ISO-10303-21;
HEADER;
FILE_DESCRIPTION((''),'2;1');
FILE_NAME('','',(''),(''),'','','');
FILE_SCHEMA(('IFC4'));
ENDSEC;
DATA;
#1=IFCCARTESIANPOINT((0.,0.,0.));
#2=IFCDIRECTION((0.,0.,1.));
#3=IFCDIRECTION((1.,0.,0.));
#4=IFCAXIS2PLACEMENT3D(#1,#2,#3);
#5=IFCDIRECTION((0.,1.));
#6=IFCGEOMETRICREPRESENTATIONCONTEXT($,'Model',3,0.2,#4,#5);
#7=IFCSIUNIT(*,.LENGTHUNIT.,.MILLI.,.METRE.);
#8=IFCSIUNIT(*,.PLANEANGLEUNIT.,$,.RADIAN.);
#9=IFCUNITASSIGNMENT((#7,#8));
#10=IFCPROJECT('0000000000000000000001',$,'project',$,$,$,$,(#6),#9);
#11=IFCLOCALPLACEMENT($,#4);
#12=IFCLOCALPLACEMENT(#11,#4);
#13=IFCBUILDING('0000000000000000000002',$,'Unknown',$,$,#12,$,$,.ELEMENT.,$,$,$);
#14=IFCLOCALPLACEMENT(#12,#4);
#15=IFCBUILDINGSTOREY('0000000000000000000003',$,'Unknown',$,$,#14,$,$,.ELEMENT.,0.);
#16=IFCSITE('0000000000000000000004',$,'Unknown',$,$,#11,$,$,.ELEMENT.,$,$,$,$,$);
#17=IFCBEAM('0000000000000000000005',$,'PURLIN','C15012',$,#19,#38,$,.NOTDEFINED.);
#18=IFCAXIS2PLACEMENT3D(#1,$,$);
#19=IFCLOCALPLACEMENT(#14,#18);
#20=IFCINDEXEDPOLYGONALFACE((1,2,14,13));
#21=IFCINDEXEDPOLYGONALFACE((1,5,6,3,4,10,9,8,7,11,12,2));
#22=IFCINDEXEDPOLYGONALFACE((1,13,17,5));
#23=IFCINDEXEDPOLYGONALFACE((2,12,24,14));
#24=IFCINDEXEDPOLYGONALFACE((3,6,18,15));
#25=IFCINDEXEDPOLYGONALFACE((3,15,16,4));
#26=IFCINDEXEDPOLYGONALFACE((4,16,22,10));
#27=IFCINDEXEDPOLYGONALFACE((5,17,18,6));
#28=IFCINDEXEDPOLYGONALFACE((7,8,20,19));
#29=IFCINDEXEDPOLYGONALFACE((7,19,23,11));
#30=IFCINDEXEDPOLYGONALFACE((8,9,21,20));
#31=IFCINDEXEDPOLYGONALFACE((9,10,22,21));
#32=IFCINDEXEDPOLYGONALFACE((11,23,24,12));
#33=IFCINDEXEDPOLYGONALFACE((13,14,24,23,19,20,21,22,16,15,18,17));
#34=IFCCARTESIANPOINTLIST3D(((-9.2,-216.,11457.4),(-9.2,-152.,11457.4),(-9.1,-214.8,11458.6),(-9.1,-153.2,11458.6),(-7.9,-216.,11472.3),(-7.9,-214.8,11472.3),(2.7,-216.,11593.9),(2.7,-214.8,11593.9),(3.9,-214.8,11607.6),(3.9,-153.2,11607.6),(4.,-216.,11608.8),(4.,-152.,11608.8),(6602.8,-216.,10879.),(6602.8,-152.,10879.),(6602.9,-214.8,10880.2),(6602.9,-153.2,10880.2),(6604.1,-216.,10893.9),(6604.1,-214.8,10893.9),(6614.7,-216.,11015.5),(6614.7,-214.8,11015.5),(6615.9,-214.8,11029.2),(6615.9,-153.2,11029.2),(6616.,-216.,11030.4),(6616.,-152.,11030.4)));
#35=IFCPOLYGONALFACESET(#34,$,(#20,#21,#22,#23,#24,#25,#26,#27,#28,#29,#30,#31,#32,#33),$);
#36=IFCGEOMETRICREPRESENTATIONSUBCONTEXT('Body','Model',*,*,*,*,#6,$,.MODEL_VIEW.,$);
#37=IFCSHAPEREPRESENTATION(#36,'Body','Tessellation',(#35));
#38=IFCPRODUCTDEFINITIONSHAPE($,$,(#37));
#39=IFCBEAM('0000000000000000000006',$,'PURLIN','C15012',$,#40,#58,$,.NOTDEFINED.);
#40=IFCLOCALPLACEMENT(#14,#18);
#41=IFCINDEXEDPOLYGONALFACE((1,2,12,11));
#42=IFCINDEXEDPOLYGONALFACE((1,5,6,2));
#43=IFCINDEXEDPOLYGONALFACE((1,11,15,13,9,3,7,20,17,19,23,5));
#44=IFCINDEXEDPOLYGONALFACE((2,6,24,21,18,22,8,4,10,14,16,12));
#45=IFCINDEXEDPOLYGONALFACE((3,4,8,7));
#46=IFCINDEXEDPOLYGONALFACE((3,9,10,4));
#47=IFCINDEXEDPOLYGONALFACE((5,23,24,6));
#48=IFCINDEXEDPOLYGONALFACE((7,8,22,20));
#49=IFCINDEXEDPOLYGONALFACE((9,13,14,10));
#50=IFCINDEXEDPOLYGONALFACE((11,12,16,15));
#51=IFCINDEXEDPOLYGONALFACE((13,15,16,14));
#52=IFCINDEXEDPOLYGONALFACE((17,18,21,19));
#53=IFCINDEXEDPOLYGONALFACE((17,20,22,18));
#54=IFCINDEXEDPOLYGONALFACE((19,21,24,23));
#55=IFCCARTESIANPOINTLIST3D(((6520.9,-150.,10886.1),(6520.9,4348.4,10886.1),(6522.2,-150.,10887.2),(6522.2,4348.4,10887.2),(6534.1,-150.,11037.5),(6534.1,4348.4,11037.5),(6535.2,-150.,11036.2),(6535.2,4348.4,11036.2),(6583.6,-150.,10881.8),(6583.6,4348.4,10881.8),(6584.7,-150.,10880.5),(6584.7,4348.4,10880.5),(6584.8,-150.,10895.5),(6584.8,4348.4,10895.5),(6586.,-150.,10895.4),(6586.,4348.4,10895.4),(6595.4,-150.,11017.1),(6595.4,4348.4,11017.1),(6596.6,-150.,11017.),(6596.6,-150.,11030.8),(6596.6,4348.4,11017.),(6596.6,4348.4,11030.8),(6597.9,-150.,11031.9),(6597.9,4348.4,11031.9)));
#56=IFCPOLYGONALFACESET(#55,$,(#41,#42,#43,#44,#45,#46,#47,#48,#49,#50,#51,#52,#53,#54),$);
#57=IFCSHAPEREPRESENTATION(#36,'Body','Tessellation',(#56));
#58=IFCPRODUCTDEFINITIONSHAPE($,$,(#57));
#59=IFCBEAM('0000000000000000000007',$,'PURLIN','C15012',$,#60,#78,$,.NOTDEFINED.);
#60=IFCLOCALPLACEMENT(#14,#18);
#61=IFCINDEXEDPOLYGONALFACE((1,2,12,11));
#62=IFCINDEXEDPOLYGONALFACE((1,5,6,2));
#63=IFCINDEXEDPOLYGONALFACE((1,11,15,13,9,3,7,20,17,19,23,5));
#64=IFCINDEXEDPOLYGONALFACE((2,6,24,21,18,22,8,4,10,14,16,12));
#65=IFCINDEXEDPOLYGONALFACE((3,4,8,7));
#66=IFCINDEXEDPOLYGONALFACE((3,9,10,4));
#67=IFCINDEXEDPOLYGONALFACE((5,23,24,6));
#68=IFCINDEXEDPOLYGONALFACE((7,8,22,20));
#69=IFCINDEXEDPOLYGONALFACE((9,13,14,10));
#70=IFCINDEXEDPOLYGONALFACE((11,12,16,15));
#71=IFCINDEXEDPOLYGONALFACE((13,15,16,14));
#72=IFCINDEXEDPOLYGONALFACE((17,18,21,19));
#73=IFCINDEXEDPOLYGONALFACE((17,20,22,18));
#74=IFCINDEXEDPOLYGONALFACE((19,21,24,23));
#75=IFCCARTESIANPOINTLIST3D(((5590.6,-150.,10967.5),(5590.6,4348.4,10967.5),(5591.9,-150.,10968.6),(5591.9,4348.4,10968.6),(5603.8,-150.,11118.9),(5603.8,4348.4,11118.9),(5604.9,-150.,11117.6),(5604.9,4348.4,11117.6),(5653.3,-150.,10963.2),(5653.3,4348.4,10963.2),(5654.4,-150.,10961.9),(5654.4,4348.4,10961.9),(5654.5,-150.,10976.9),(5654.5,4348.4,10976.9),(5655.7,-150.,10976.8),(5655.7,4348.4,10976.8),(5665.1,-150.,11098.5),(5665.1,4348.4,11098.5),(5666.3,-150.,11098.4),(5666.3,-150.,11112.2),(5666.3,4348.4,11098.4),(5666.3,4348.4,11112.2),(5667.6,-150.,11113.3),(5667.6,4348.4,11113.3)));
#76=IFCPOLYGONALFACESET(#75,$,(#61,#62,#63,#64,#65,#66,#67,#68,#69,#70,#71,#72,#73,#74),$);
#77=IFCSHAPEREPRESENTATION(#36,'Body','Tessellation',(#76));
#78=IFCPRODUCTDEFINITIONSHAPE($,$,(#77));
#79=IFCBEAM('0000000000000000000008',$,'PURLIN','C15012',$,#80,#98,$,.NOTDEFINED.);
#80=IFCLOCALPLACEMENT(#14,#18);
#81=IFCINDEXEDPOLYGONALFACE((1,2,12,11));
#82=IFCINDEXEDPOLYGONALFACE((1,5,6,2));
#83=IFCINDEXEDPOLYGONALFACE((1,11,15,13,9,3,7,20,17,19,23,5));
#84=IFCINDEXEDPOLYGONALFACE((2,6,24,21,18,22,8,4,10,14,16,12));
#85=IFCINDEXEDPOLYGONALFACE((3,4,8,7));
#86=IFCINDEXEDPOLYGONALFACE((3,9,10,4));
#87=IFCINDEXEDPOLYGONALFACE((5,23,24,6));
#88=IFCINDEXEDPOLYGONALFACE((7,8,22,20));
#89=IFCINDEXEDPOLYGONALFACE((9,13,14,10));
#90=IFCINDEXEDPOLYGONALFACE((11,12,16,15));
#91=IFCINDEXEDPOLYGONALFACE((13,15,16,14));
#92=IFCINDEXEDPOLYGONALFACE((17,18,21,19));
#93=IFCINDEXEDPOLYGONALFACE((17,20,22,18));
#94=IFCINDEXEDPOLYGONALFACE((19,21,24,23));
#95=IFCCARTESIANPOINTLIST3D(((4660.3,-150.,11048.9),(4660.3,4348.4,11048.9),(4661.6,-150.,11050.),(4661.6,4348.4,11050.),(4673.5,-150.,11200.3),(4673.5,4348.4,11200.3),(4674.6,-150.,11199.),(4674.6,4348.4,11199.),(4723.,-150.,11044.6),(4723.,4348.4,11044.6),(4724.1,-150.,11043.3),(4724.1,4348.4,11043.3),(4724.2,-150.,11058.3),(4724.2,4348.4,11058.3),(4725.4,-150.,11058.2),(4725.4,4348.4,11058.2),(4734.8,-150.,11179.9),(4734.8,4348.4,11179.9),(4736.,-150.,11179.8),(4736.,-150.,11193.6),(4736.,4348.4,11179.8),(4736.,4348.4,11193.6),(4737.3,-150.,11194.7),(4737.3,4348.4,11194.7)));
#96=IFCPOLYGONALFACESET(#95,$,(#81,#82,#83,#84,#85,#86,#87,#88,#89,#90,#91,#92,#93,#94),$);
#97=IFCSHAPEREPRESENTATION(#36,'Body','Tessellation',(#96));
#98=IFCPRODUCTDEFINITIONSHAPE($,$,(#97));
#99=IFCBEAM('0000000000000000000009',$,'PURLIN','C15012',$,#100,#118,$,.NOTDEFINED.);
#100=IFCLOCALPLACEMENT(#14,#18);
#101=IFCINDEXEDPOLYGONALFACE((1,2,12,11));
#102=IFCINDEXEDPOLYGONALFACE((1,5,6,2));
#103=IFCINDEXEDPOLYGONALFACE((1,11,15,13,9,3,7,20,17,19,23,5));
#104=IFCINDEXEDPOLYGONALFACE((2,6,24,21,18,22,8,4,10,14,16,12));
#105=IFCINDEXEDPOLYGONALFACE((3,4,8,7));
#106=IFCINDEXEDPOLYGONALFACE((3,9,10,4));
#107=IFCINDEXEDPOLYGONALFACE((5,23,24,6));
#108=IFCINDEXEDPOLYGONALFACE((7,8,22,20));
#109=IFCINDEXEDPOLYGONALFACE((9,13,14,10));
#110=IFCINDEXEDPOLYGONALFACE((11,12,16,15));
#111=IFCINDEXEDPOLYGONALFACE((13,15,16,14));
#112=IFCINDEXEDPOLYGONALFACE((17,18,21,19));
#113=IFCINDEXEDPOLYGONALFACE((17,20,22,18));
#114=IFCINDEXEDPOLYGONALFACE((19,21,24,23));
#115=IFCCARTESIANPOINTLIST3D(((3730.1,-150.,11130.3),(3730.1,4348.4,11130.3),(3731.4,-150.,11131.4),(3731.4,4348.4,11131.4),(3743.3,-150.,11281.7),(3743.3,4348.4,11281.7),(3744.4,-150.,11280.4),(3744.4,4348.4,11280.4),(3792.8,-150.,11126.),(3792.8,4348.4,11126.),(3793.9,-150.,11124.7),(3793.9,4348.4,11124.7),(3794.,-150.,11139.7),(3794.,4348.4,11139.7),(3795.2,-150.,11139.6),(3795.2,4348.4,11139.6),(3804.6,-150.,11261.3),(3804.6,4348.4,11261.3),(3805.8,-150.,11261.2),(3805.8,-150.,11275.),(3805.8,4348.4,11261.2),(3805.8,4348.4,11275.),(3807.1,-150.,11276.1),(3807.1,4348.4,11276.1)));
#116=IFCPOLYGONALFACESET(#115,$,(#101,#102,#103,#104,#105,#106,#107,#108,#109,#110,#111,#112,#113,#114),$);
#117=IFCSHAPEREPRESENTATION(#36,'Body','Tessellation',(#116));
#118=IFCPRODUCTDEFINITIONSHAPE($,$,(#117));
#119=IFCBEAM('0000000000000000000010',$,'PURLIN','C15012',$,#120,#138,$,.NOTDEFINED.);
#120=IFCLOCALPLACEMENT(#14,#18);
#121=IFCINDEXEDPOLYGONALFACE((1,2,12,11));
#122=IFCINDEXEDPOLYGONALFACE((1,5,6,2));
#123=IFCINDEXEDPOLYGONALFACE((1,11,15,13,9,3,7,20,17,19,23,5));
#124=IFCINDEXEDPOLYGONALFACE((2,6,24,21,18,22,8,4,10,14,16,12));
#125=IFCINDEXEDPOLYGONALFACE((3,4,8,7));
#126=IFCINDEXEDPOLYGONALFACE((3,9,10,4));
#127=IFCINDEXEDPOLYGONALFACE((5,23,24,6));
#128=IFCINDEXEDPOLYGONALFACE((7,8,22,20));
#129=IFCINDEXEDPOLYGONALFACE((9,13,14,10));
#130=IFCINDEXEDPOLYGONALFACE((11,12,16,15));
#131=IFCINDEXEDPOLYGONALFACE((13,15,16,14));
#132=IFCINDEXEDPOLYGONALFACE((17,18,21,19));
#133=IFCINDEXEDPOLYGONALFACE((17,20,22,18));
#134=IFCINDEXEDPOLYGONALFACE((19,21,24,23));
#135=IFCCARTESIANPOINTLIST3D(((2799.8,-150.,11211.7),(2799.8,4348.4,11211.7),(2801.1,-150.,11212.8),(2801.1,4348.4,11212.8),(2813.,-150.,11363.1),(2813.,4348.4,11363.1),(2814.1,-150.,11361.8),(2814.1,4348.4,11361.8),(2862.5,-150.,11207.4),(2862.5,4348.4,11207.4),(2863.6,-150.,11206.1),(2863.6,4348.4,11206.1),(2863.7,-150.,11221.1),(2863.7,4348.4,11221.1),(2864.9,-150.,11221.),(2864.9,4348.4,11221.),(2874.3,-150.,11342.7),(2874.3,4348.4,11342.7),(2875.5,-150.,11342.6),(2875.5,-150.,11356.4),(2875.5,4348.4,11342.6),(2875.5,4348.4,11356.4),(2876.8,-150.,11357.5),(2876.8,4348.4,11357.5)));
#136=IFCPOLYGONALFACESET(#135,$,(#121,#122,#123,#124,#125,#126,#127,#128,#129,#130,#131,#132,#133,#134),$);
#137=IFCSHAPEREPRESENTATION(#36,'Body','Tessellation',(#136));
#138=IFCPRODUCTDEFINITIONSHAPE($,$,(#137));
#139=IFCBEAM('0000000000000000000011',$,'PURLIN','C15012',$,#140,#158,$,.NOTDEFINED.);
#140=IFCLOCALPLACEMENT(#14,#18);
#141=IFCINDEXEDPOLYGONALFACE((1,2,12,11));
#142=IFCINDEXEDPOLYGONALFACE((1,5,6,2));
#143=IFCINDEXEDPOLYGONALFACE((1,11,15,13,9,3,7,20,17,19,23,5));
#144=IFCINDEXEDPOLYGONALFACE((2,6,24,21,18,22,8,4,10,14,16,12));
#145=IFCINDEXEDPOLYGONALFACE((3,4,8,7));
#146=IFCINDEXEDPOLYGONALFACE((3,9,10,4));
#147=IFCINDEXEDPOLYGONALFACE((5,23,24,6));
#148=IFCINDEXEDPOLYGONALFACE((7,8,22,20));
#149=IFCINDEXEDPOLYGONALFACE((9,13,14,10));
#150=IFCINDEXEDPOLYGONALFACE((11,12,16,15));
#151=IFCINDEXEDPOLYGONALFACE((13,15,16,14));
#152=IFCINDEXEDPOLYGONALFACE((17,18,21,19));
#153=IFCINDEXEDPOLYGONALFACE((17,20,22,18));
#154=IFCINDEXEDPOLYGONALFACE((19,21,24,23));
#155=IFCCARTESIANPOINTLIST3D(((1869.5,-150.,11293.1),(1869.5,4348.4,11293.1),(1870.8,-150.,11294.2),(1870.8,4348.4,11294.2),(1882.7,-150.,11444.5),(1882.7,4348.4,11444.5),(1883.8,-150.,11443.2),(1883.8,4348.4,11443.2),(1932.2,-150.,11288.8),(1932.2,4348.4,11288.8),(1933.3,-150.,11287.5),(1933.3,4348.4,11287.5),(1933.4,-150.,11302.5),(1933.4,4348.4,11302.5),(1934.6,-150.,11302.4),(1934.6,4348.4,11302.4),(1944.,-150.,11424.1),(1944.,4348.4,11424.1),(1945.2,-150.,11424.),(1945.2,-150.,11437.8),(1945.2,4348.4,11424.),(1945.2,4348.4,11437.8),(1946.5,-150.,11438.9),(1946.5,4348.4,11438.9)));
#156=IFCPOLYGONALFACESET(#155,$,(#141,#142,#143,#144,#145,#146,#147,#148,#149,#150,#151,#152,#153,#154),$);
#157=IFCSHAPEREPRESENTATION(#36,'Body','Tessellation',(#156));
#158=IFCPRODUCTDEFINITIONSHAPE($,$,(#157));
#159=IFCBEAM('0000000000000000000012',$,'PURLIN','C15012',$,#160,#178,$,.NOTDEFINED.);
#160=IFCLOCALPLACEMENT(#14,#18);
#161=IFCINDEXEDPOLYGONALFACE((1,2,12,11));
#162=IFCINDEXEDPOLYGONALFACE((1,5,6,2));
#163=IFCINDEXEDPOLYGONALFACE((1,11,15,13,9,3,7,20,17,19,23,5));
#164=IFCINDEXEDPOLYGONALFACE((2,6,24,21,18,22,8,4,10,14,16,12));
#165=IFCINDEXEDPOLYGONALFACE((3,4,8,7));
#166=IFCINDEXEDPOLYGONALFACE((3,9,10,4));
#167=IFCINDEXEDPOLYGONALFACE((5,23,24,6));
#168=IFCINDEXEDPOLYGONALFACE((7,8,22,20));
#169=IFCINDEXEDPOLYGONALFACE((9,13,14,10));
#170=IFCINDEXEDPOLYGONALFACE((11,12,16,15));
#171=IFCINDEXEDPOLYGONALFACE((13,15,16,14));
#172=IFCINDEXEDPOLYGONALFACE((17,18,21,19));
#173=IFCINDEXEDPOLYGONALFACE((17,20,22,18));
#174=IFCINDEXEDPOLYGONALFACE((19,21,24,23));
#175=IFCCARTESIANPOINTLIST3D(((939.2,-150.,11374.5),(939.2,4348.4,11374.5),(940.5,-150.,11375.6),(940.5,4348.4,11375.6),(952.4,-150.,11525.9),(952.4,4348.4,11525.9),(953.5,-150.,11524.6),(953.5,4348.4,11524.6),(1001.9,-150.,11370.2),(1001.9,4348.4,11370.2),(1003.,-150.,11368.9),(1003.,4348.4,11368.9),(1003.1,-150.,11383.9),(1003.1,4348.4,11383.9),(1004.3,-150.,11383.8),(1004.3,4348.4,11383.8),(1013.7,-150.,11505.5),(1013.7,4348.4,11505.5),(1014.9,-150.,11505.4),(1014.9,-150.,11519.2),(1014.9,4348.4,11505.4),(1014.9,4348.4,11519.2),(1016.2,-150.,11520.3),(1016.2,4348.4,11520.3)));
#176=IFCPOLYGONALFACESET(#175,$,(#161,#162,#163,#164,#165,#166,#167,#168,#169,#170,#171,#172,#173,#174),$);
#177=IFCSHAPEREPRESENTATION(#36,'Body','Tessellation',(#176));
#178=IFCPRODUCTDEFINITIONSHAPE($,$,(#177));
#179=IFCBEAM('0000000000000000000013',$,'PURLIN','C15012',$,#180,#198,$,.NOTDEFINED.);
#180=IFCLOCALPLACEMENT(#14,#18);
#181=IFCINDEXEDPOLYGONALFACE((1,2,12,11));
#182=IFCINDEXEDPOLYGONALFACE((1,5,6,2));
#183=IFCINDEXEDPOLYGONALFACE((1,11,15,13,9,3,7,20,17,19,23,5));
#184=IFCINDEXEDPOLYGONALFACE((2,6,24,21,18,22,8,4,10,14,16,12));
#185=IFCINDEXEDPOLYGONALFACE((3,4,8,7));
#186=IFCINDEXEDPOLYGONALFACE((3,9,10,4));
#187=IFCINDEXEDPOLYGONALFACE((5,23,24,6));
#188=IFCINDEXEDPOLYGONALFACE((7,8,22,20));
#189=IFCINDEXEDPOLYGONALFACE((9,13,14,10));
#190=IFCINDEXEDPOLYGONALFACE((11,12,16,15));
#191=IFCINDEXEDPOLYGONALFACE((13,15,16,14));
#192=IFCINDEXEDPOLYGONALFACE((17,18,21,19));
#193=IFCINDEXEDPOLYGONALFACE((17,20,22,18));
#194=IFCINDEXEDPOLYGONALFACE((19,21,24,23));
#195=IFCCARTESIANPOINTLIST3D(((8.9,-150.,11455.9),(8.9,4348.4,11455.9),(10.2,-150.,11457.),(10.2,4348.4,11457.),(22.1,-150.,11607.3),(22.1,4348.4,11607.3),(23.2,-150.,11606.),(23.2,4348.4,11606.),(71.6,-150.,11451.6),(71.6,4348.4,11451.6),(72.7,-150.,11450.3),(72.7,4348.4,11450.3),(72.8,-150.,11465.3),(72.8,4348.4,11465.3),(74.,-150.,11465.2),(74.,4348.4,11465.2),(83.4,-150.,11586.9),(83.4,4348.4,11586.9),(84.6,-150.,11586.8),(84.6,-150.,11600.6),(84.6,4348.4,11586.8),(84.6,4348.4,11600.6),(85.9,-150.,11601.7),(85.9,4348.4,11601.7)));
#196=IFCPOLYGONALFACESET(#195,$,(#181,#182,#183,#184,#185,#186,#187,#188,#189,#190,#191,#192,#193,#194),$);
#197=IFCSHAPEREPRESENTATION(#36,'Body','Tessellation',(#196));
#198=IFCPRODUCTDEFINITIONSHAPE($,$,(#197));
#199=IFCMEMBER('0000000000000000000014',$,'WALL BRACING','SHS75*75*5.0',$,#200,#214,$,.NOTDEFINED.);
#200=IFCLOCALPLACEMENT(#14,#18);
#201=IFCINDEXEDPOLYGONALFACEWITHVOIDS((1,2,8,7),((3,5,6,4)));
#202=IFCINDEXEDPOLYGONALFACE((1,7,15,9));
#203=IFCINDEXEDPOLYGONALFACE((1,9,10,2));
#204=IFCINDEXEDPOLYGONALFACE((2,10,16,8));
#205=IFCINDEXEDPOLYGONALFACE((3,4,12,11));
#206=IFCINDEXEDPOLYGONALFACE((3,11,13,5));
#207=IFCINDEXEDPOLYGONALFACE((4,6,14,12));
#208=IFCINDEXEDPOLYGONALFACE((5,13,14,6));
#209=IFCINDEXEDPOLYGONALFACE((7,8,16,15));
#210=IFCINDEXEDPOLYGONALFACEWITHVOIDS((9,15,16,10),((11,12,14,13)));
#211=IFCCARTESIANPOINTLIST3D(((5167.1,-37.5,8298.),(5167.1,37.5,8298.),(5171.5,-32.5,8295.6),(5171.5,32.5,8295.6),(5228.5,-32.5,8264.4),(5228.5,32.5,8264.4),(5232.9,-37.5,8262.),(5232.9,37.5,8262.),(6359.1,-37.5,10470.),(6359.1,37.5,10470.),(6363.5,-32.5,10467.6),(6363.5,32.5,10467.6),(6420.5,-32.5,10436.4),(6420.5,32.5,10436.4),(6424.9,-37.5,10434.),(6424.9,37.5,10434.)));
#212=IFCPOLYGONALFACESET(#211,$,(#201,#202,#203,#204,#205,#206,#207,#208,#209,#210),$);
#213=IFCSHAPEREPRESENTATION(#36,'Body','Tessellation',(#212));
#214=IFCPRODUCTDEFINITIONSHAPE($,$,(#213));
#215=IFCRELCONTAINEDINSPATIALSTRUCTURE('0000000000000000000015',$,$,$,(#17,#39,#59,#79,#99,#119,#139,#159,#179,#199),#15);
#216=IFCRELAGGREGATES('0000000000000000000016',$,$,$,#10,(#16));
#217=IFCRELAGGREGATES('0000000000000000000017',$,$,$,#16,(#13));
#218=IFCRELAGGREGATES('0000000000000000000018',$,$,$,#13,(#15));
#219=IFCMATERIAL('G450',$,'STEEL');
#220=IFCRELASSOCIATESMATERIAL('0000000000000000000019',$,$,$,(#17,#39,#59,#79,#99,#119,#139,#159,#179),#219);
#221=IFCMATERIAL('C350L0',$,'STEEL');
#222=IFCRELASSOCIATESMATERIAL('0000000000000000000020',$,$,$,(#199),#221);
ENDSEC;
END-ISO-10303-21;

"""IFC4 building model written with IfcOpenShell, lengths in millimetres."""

from ifc_helpers import new_model, si_unit, direction, frame, origin_with_axes, place, context, subcontext, project, spatial, line, indexed_curve, outline, extrude, material, element, save


model = new_model("IFC4")

# Units and contexts
model_context = context("Model", 3, precision=0.2, world=origin_with_axes(), true_north=direction((0.0, 1.0)))
body_context = subcontext(model_context, "Body", "Model", "MODEL_VIEW")
ifc_project = project(units=[si_unit("LENGTHUNIT", "METRE", prefix="MILLI"), si_unit("PLANEANGLEUNIT", "RADIAN")], contexts=[model_context])

# Site, building, storey
site_placement = place(None, origin_with_axes())
site = spatial("IfcSite", under=ifc_project, at=site_placement, Name="Unknown", CompositionType="ELEMENT")
building_placement = place(site_placement, origin_with_axes())
building = spatial("IfcBuilding", under=site, at=building_placement, Name="Unknown", CompositionType="ELEMENT")
storey_placement = place(building_placement, origin_with_axes())
storey = spatial("IfcBuildingStorey", under=building, at=storey_placement, Name="Unknown", CompositionType="ELEMENT", Elevation=0.0)

# Shared definitions
ifc_material_1 = material(Name="C350L0", Category="STEEL")

# Beams
ifc_material_2 = material(Name="G450", Category="STEEL")
beam_placement = place(storey_placement, frame((-2.6, -184.0, 11533.1), z_axis=(0.0, -1.0, 0.0), x_axis=(0.996196, 0.0, -0.087145)))
element("IfcBeam", 1, at=beam_placement, inside=storey, material=ifc_material_2, Name="PURLIN", Description="C15012", PredefinedType="NOTDEFINED", context=body_context, shape_type="SolidModel", body=[
    extrude(outline(indexed_curve([(32.0, -76.0), (32.0, -61.0), (30.8, -61.0), (30.8, -74.8), (-30.8, -74.8), (-30.8, 74.8), (30.8, 74.8), (30.8, 61.0), (32.0, 61.0), (32.0, 76.0), (-32.0, 76.0), (-32.0, -76.0)], segments=[line(1, 2, 3, 4, 5, 6, 7, 8, 9, 10, 11, 12, 1)])), frame((0.0, 0.0, 0.0), z_axis=(-1.0, 0.0, 0.0), x_axis=(0.0, 0.0, 1.0)), (0.0, 0.0, -1.0), 6637.3),
])
for number, where, z_axis, x_axis, name in (
    (2, (6559.4, -150.0, 10959.0), (0.996195, 0.0, -0.087156), (0.0, 1.0, 0.0), "PURLIN"),
    (3, (5629.1, -150.0, 11040.4), (0.996195, 0.0, -0.087156), (0.0, 1.0, 0.0), "PURLIN"),
    (4, (4698.8, -150.0, 11121.8), (0.996195, 0.0, -0.087156), (0.0, 1.0, 0.0), "PURLIN"),
    (5, (3768.6, -150.0, 11203.2), (0.996195, 0.0, -0.087156), (0.0, 1.0, 0.0), "PURLIN"),
    (6, (2838.3, -150.0, 11284.6), (0.996195, 0.0, -0.087156), (0.0, 1.0, 0.0), "PURLIN"),
    (7, (1908.0, -150.0, 11366.0), (0.996195, 0.0, -0.087156), (0.0, 1.0, 0.0), "PURLIN"),
    (8, (977.7, -150.0, 11447.4), (0.996195, 0.0, -0.087156), (0.0, 1.0, 0.0), "PURLIN"),
    (9, (47.4, -150.0, 11528.8), (0.996195, 0.0, -0.087156), (0.0, 1.0, 0.0), "PURLIN"),
):
    element("IfcBeam", number, at=place(storey_placement, frame(where, z_axis=z_axis, x_axis=x_axis)), inside=storey, material=ifc_material_2, Name=name, Description="C15012", PredefinedType="NOTDEFINED", context=body_context, shape_type="SolidModel", body=[
        extrude(outline(indexed_curve([(32.0, -76.0), (32.0, -61.0), (30.8, -61.0), (30.8, -74.8), (-30.8, -74.8), (-30.8, 74.8), (30.8, 74.8), (30.8, 61.0), (32.0, 61.0), (32.0, 76.0), (-32.0, 76.0), (-32.0, -76.0)], segments=[line(1, 2, 3, 4, 5, 6, 7, 8, 9, 10, 11, 12, 1)])), frame((0.0, 0.0, 0.0), z_axis=(-1.0, 0.0, 0.0), x_axis=(0.0, 0.0, 1.0)), (0.0, 0.0, -1.0), 4498.4),
    ])

# Member
member_1_placement = place(storey_placement, frame((6392.0, 0.0, 10452.0), z_axis=(-0.876659, 0.0, 0.481113), x_axis=(-0.481113, 0.0, -0.876659)))
element("IfcMember", 10, at=member_1_placement, inside=storey, material=ifc_material_1, Name="WALL BRACING", Description="SHS75*75*5.0", PredefinedType="NOTDEFINED", context=body_context, shape_type="SolidModel", body=[
    extrude(outline(indexed_curve([(-37.5, -37.5), (37.5, -37.5), (37.5, 37.5), (-37.5, 37.5)], segments=[line(1, 2, 3, 4, 1)]), holes=[indexed_curve([(-32.5, -32.5), (-32.5, 32.5), (32.5, 32.5), (32.5, -32.5)], segments=[line(1, 2, 3, 4, 1)])]), frame((0.0, 0.0, 0.0), z_axis=(-1.0, 0.0, 0.0), x_axis=(0.0, 0.0, 1.0)), (0.0, 0.0, -1.0), 2477.6),
])

save(model, "model.ifc")
